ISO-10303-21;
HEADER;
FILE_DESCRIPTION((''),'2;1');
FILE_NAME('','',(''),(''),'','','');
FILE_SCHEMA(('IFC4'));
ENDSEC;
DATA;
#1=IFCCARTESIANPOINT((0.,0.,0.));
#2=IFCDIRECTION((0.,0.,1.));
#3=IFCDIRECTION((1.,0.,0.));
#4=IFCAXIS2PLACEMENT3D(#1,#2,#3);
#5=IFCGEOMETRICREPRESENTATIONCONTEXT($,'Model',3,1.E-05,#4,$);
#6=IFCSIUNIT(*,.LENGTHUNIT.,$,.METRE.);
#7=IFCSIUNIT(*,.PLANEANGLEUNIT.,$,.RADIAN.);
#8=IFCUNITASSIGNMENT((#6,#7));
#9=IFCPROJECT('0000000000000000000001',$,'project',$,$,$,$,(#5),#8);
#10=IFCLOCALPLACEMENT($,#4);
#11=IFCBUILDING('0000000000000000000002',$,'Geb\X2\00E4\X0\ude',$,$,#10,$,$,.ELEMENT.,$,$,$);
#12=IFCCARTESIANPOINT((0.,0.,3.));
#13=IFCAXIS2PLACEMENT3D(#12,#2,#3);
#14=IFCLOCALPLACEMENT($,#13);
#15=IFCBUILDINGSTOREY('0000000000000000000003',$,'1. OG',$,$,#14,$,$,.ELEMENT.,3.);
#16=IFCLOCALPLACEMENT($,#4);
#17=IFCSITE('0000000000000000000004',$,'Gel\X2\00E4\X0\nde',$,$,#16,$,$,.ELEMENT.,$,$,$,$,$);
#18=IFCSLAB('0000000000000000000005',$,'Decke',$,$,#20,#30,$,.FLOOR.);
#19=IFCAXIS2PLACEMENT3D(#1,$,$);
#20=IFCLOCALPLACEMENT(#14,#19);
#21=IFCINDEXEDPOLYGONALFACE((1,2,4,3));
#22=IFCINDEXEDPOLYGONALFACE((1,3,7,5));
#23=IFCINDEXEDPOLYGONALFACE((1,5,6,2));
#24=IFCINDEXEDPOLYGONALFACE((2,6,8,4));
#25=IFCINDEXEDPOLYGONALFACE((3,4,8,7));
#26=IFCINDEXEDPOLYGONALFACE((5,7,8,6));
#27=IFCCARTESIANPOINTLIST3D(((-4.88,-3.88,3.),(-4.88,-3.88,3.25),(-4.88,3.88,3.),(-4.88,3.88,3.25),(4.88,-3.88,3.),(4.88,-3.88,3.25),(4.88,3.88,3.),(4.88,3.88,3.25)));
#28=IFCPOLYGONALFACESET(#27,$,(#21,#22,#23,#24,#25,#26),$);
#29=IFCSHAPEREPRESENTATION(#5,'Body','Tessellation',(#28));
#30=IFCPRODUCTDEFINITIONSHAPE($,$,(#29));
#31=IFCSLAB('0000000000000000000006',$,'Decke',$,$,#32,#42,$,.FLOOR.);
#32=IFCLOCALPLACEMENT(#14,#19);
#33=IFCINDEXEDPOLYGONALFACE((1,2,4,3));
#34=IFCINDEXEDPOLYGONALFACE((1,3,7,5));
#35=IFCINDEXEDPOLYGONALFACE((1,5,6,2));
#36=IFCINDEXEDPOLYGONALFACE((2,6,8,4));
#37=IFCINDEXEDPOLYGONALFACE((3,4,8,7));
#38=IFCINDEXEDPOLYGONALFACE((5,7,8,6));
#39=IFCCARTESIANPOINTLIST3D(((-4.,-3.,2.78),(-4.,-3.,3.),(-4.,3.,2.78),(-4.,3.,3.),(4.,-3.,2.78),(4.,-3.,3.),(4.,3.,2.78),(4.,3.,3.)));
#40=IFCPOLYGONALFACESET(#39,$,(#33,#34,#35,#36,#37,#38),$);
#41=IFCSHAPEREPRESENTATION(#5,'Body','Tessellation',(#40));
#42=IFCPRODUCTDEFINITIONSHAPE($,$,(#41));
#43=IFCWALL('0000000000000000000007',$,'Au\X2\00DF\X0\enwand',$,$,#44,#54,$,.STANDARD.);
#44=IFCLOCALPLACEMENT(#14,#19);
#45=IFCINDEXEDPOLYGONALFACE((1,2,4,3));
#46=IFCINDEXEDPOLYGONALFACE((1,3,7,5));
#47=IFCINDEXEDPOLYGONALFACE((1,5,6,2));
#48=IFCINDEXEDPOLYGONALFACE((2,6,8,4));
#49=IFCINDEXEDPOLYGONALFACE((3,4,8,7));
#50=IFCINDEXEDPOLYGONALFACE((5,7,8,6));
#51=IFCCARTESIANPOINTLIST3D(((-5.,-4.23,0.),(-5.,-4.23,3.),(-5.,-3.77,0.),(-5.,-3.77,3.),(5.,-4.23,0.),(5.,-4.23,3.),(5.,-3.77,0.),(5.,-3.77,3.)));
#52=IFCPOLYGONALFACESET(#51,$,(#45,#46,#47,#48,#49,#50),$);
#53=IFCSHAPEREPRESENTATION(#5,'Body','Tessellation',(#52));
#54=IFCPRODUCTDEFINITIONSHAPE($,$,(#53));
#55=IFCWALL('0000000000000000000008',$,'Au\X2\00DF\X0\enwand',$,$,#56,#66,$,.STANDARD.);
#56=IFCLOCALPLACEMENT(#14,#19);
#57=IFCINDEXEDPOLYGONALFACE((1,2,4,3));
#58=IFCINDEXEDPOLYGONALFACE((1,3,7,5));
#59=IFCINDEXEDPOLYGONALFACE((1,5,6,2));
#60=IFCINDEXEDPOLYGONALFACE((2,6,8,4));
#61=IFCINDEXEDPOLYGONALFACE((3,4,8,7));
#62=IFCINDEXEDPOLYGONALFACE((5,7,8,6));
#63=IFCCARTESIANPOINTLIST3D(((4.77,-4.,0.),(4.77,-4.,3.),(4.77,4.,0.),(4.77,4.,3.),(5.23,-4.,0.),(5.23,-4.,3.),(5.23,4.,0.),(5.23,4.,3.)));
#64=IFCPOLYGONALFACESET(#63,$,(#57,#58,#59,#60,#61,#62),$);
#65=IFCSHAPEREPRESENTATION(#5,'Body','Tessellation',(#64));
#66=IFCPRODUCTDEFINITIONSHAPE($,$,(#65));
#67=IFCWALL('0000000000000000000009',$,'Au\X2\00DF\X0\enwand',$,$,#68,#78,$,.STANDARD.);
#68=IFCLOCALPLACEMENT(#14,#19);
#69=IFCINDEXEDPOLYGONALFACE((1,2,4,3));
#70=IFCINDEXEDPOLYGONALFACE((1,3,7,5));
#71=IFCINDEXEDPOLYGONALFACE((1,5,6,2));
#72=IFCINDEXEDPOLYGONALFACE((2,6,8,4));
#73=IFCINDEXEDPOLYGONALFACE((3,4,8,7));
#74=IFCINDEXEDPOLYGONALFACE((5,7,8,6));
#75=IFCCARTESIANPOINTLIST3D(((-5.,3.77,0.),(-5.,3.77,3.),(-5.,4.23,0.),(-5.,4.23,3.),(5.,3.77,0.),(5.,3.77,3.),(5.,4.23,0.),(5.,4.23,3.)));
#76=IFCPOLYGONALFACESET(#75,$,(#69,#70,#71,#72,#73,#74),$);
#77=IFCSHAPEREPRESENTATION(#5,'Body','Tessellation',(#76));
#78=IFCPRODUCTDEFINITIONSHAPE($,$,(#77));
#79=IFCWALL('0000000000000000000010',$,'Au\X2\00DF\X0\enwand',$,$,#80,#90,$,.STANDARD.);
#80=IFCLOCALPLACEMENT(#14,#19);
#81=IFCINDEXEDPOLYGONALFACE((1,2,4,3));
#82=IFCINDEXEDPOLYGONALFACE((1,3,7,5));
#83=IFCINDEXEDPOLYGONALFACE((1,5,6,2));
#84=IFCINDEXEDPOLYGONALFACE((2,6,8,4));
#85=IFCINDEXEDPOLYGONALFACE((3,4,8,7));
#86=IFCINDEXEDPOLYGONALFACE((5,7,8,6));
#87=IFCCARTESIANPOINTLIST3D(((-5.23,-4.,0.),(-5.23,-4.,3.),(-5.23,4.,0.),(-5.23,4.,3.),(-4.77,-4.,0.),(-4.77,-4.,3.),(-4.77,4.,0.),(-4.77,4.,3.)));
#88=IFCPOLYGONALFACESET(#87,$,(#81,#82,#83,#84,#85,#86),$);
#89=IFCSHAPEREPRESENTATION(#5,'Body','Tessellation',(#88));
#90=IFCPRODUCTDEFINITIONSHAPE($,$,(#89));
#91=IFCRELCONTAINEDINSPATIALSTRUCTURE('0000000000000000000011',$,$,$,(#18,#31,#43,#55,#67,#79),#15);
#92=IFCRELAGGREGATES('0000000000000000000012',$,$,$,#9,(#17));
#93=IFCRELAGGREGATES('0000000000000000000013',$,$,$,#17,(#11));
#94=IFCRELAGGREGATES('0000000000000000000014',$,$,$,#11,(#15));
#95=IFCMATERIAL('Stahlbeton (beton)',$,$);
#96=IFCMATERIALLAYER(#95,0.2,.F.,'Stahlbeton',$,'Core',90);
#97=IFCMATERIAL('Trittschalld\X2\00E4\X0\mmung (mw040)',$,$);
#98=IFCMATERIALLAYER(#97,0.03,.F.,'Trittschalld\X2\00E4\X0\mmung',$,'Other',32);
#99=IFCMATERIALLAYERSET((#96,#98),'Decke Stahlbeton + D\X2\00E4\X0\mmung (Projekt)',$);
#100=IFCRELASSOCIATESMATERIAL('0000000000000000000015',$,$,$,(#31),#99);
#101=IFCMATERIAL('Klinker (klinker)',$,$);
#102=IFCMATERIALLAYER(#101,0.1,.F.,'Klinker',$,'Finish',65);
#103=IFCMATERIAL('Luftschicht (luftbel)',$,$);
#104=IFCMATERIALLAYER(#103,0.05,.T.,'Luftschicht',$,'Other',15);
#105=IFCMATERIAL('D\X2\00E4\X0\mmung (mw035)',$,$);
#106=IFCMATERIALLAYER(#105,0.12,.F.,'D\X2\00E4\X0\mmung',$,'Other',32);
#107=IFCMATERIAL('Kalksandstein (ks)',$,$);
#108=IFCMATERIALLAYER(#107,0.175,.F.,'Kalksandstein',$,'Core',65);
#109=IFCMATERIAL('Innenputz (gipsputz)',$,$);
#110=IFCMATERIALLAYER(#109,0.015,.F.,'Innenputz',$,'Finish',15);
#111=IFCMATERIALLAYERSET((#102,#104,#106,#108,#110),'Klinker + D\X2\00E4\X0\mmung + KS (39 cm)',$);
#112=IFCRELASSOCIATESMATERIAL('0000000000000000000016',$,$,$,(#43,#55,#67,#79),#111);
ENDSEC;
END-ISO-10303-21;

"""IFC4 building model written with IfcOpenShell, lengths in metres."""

from ifc_helpers import new_model, si_unit, frame, origin_with_axes, origin_2d, place, context, project, spatial, polyline, rectangle, outline, extrude, material, layer, layer_set, layer_usage, element, save


model = new_model("IFC4")

# Units and contexts
model_context = context("Model", 3, precision=1e-05, world=origin_with_axes())
ifc_project = project(units=[si_unit("LENGTHUNIT", "METRE"), si_unit("PLANEANGLEUNIT", "RADIAN")], contexts=[model_context])

# Site, building, storey
site_placement = place(None, origin_with_axes())
site = spatial("IfcSite", under=ifc_project, at=site_placement, Name="Gelände", CompositionType="ELEMENT")
building_placement = place(None, origin_with_axes())
building = spatial("IfcBuilding", under=site, at=building_placement, Name="Gebäude", CompositionType="ELEMENT")
storey_placement = place(None, frame((0.0, 0.0, 3.0), z_axis=(0.0, 0.0, 1.0), x_axis=(1.0, 0.0, 0.0)))
storey = spatial("IfcBuildingStorey", under=building, at=storey_placement, Name="1. OG", CompositionType="ELEMENT", Elevation=3.0)

# Slabs
slab_1_placement = place(None, frame((0.0, 0.0, 6.0), z_axis=(0.0, 0.0, 1.0), x_axis=(1.0, 0.0, 0.0)))
element("IfcSlab", 1, at=slab_1_placement, inside=storey, Name="Decke", PredefinedType="FLOOR", context=model_context, shape_type="SweptSolid", body=[
    extrude(outline(polyline([(-4.88, -3.88), (4.88, -3.88), (4.88, 3.88), (-4.88, 3.88), (-4.88, -3.88)])), origin_with_axes(), (0.0, 0.0, 1.0), 0.25),
])
ifc_material_1 = material(Name="Stahlbeton (beton)")
ifc_layer_1 = layer(ifc_material_1, 0.2, ventilated=False, Name="Stahlbeton", Category="Core", Priority=90)
ifc_material_2 = material(Name="Trittschalldämmung (mw040)")
ifc_layer_2 = layer(ifc_material_2, 0.03, ventilated=False, Name="Trittschalldämmung", Category="Other", Priority=32)
ifc_layer_set_1 = layer_set([ifc_layer_1, ifc_layer_2], Name="Decke Stahlbeton + Dämmung (Projekt)")
slab_2_placement = place(None, frame((0.0, 0.0, 5.78), z_axis=(0.0, 0.0, 1.0), x_axis=(1.0, 0.0, 0.0)))
element("IfcSlab", 2, at=slab_2_placement, inside=storey, material=ifc_layer_set_1, Name="Decke", PredefinedType="FLOOR", context=model_context, shape_type="SweptSolid", body=[
    extrude(outline(polyline([(-4.0, -3.0), (4.0, -3.0), (4.0, 3.0), (-4.0, 3.0), (-4.0, -3.0)])), origin_with_axes(), (0.0, 0.0, 1.0), 0.22),
])

# Walls
ifc_material_3 = material(Name="Klinker (klinker)")
ifc_layer_3 = layer(ifc_material_3, 0.1, ventilated=False, Name="Klinker", Category="Finish", Priority=65)
ifc_material_4 = material(Name="Luftschicht (luftbel)")
ifc_layer_4 = layer(ifc_material_4, 0.05, ventilated=True, Name="Luftschicht", Category="Other", Priority=15)
ifc_material_5 = material(Name="Dämmung (mw035)")
ifc_layer_5 = layer(ifc_material_5, 0.12, ventilated=False, Name="Dämmung", Category="Other", Priority=32)
ifc_material_6 = material(Name="Kalksandstein (ks)")
ifc_layer_6 = layer(ifc_material_6, 0.175, ventilated=False, Name="Kalksandstein", Category="Core", Priority=65)
ifc_material_7 = material(Name="Innenputz (gipsputz)")
ifc_layer_7 = layer(ifc_material_7, 0.015, ventilated=False, Name="Innenputz", Category="Finish", Priority=15)
ifc_layer_set_2 = layer_set([ifc_layer_3, ifc_layer_4, ifc_layer_5, ifc_layer_6, ifc_layer_7], Name="Klinker + Dämmung + KS (39 cm)")
ifc_layer_usage_1 = layer_usage(ifc_layer_set_2, "AXIS2", "NEGATIVE", 0.23)
wall_1_placement = place(None, frame((0.0, -4.0, 3.0), z_axis=(0.0, 0.0, 1.0), x_axis=(1.0, 0.0, 0.0)))
element("IfcWall", 3, at=wall_1_placement, inside=storey, material=ifc_layer_usage_1, Name="Außenwand", PredefinedType="STANDARD", context=model_context, shape_type="SweptSolid", body=[
    extrude(rectangle(XDim=10.0, YDim=0.46, at=origin_2d()), origin_with_axes(), (0.0, 0.0, 1.0), 3.0),
])
ifc_layer_usage_2 = layer_usage(ifc_layer_set_2, "AXIS2", "NEGATIVE", 0.23)
wall_2_placement = place(None, frame((5.0, 0.0, 3.0), z_axis=(0.0, 0.0, 1.0), x_axis=(0.0, 1.0, 0.0)))
element("IfcWall", 4, at=wall_2_placement, inside=storey, material=ifc_layer_usage_2, Name="Außenwand", PredefinedType="STANDARD", context=model_context, shape_type="SweptSolid", body=[
    extrude(rectangle(XDim=8.0, YDim=0.46, at=origin_2d()), origin_with_axes(), (0.0, 0.0, 1.0), 3.0),
])
ifc_layer_usage_3 = layer_usage(ifc_layer_set_2, "AXIS2", "NEGATIVE", 0.23)
wall_3_placement = place(None, frame((0.0, 4.0, 3.0), z_axis=(0.0, 0.0, 1.0), x_axis=(-1.0, 0.0, 0.0)))
element("IfcWall", 5, at=wall_3_placement, inside=storey, material=ifc_layer_usage_3, Name="Außenwand", PredefinedType="STANDARD", context=model_context, shape_type="SweptSolid", body=[
    extrude(rectangle(XDim=10.0, YDim=0.46, at=origin_2d()), origin_with_axes(), (0.0, 0.0, 1.0), 3.0),
])
ifc_layer_usage_4 = layer_usage(ifc_layer_set_2, "AXIS2", "NEGATIVE", 0.23)
wall_4_placement = place(None, frame((-5.0, 0.0, 3.0), z_axis=(0.0, 0.0, 1.0), x_axis=(0.0, -1.0, 0.0)))
element("IfcWall", 6, at=wall_4_placement, inside=storey, material=ifc_layer_usage_4, Name="Außenwand", PredefinedType="STANDARD", context=model_context, shape_type="SweptSolid", body=[
    extrude(rectangle(XDim=8.0, YDim=0.46, at=origin_2d()), origin_with_axes(), (0.0, 0.0, 1.0), 3.0),
])

save(model, "model.ifc")
